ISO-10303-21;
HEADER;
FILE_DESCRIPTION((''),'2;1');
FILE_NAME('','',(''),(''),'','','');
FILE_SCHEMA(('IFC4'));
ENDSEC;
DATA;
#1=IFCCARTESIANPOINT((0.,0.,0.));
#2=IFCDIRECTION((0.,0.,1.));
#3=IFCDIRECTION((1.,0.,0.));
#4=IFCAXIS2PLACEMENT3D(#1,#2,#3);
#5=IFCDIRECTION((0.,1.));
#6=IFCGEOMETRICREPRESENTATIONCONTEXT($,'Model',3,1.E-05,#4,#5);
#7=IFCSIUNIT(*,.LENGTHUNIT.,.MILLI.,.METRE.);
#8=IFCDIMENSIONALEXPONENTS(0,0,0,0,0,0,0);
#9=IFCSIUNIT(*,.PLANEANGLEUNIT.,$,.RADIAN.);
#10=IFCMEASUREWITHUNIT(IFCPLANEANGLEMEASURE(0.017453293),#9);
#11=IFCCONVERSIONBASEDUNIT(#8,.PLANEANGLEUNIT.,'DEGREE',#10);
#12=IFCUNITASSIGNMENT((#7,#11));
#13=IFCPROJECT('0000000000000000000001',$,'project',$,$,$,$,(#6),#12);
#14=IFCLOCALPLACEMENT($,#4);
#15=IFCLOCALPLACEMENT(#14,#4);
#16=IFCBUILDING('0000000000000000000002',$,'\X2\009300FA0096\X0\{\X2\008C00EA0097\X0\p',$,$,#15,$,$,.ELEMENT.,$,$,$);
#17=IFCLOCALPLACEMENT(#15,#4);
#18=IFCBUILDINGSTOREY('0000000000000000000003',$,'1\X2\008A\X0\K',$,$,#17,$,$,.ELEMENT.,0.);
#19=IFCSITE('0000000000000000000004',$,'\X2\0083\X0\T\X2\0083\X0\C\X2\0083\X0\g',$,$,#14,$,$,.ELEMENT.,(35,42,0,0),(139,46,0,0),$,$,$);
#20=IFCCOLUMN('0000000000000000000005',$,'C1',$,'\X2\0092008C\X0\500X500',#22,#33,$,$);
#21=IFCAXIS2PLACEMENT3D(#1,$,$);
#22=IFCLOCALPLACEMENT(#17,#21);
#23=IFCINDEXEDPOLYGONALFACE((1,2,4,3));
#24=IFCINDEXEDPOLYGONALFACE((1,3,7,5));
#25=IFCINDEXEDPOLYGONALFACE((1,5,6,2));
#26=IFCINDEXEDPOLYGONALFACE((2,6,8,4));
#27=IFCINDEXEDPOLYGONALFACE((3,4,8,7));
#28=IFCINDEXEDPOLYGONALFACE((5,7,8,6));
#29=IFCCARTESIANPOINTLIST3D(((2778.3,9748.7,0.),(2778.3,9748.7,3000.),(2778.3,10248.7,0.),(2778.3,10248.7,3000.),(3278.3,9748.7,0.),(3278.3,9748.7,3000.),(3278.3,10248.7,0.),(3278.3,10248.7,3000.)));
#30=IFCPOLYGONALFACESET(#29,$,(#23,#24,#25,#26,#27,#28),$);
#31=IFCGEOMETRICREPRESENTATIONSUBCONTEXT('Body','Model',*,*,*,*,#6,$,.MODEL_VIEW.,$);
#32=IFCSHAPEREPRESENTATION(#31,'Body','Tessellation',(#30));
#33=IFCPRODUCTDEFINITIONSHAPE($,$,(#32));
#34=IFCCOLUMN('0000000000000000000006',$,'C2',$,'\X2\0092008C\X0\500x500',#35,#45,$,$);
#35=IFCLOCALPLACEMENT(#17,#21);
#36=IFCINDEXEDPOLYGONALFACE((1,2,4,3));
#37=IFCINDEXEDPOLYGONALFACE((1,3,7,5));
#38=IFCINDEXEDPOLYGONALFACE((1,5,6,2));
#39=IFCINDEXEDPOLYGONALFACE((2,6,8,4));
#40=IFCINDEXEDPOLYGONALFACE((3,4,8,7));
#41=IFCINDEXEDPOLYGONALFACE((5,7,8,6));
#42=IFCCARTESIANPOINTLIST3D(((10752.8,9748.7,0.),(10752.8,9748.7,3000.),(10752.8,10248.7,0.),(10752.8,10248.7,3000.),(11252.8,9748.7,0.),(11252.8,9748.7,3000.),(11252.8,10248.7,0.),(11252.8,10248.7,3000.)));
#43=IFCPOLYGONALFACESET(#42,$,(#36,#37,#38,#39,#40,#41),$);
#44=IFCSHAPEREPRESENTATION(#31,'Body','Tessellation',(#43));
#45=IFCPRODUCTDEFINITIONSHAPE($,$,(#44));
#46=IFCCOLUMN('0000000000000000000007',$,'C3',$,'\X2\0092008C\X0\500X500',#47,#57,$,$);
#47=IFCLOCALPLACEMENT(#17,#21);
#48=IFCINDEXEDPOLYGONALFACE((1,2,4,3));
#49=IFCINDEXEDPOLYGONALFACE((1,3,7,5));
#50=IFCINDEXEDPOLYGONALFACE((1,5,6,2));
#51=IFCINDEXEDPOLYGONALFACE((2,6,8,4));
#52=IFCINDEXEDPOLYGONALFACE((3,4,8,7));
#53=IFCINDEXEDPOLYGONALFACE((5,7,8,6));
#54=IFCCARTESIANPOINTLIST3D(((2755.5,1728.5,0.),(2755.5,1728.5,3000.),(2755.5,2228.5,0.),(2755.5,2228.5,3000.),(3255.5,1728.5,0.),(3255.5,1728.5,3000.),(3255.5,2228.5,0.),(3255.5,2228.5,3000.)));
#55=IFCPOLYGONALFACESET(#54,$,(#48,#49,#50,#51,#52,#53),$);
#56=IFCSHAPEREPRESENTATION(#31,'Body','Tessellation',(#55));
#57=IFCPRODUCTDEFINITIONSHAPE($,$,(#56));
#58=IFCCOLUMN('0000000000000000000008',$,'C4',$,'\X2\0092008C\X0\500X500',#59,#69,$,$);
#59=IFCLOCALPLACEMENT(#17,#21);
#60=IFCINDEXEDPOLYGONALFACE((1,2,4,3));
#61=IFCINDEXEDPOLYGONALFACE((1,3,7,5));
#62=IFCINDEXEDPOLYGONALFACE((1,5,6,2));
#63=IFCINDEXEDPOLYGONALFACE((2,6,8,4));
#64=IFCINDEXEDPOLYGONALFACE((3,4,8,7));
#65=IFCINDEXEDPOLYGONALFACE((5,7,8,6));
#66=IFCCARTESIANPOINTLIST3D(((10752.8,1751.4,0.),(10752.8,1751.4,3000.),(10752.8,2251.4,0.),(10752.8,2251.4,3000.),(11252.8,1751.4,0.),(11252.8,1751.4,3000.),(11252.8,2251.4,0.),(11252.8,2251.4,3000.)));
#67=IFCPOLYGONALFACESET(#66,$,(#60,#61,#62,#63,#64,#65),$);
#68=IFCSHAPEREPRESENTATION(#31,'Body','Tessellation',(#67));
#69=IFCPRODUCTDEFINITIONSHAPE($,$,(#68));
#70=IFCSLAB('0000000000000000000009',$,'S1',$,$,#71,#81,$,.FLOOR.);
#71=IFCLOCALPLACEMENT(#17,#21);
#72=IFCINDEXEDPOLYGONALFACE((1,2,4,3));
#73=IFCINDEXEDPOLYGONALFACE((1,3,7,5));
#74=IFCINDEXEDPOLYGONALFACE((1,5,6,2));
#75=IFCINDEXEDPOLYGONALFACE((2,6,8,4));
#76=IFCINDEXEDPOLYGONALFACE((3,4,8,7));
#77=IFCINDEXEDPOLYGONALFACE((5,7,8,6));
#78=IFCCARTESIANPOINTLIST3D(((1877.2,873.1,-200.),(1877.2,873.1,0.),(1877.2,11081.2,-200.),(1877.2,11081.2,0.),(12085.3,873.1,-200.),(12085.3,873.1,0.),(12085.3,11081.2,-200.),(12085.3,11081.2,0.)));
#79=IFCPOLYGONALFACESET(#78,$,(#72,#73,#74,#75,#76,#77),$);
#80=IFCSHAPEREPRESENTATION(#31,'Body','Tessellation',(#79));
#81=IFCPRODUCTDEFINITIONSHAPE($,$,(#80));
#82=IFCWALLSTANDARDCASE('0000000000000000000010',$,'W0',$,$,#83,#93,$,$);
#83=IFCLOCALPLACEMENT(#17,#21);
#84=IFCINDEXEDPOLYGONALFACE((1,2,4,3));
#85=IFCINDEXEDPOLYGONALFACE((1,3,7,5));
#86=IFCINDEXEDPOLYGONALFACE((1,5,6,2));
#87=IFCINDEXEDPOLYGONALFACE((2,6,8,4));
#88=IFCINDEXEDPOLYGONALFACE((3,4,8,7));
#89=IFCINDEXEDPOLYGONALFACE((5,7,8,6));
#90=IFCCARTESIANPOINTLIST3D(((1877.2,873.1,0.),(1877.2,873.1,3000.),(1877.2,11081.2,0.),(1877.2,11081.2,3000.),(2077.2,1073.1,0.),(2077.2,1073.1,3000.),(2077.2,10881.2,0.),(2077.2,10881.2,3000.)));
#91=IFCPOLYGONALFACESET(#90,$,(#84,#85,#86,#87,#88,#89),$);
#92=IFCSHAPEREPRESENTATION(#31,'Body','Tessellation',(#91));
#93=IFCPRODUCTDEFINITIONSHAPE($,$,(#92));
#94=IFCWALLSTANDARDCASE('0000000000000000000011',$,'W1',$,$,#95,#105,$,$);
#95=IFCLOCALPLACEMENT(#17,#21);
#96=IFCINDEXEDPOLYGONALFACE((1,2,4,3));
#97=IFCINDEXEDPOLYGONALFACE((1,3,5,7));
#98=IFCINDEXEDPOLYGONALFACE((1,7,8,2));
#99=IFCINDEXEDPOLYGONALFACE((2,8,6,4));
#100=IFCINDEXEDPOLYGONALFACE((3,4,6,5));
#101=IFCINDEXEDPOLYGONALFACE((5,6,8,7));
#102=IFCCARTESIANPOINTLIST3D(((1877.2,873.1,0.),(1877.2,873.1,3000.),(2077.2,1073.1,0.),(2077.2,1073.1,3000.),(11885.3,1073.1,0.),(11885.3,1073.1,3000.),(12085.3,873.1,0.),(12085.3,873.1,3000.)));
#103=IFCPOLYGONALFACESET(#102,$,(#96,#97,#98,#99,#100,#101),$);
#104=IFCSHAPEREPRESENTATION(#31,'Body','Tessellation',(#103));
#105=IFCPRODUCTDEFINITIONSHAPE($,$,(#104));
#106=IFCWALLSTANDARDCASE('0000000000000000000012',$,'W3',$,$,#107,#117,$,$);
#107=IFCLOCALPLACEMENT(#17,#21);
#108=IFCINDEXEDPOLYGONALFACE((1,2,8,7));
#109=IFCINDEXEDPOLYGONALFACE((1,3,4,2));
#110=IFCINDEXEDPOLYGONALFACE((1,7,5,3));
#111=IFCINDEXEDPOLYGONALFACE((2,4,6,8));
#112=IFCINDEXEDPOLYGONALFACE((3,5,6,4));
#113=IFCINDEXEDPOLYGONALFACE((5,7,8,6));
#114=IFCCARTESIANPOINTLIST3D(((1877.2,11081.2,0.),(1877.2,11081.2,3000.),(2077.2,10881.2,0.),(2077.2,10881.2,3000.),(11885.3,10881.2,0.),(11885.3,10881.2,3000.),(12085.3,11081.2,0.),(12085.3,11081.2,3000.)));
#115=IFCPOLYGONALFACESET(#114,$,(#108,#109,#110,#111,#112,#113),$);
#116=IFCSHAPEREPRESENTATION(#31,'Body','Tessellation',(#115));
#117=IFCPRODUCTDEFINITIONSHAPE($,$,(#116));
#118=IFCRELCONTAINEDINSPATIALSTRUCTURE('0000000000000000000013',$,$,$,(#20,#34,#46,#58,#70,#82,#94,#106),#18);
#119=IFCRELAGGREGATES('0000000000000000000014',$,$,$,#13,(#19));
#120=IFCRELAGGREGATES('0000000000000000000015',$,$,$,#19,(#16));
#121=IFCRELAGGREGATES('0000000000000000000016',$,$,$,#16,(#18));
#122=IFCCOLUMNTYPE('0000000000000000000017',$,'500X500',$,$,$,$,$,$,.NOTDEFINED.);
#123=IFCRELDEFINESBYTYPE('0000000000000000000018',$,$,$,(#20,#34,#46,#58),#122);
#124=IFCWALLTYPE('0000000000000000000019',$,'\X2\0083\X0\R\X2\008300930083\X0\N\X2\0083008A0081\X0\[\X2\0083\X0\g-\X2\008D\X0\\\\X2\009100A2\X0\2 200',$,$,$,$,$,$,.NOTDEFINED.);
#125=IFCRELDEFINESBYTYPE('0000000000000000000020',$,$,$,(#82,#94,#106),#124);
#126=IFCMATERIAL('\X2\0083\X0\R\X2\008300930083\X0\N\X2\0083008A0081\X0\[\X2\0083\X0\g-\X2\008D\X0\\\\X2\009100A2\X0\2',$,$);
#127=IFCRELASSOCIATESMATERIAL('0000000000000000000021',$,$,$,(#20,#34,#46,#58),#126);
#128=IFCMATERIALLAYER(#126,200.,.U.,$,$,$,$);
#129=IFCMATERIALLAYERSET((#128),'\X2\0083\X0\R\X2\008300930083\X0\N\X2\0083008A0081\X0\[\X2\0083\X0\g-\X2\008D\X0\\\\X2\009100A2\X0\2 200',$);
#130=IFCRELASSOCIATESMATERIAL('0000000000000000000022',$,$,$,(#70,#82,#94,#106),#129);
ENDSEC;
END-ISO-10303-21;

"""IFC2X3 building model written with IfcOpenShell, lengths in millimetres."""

from ifc_helpers import new_model, entity, si_unit, converted_unit, direction, frame, origin_with_axes, origin_2d_with_axis, place, context, subcontext, project, spatial, polyline, rectangle, outline, extrude, material, layer, layer_set, layer_usage, type_object, element, save


model = new_model("IFC2X3")

# Units and contexts
model_context = context("Model", 3, precision=1e-05, world=origin_with_axes(), true_north=direction((0.0, 1.0)))
body_context = subcontext(model_context, "Body", "Model", "MODEL_VIEW")
ifc_project = project(units=[si_unit("LENGTHUNIT", "METRE", prefix="MILLI"), converted_unit("PLANEANGLEUNIT", "DEGREE", entity("IfcPlaneAngleMeasure", 0.017453293), si_unit("PLANEANGLEUNIT", "RADIAN"), dimensions=[0, 0, 0, 0, 0, 0, 0])], contexts=[model_context])

# Site, building, storey
site_placement = place(None, origin_with_axes())
site = spatial("IfcSite", under=ifc_project, at=site_placement, Name="\u0083T\u0083C\u0083g", CompositionType="ELEMENT", RefLatitude=(35, 42, 0, 0), RefLongitude=(139, 46, 0, 0))
building_placement = place(site_placement, origin_with_axes())
building = spatial("IfcBuilding", under=site, at=building_placement, Name="\u0093ú\u0096{\u008cê\u0097p", CompositionType="ELEMENT")
storey_placement = place(building_placement, origin_with_axes())
storey = spatial("IfcBuildingStorey", under=building, at=storey_placement, Name="1\u008aK", CompositionType="ELEMENT", Elevation=0.0)

# Columns
ifc_material = material(Name="\u0083R\u0083\u0093\u0083N\u0083\u008a\u0081[\u0083g-\u008d\\\u0091¢2")
column_type = type_object("IfcColumnType", Name="500X500", PredefinedType="NOTDEFINED")
column_1_placement = place(storey_placement, frame((3028.3, 9998.7, 0.0), z_axis=(0.0, 0.0, 1.0), x_axis=(1.0, 0.0, 0.0)))
element("IfcColumn", 1, at=column_1_placement, inside=storey, type_object=column_type, material=ifc_material, Name="C1", ObjectType="\u0092\u008c500X500", context=body_context, shape_type="SweptSolid", body=[
    extrude(rectangle(XDim=500.0, YDim=500.0, at=origin_2d_with_axis()), origin_with_axes(), (0.0, 0.0, 1.0), 3000.0),
])
column_2_placement = place(storey_placement, frame((11002.8, 9998.7, 0.0), z_axis=(0.0, 0.0, 1.0), x_axis=(1.0, 0.0, 0.0)))
element("IfcColumn", 2, at=column_2_placement, inside=storey, type_object=column_type, material=ifc_material, Name="C2", ObjectType="\u0092\u008c500x500", context=body_context, shape_type="SweptSolid", body=[
    extrude(rectangle(XDim=500.0, YDim=500.0, at=origin_2d_with_axis()), origin_with_axes(), (0.0, 0.0, 1.0), 3000.0),
])
for number, where, z_axis, x_axis, name in (
    (3, (3005.5, 1978.5, 0.0), (0.0, 0.0, 1.0), (1.0, 0.0, 0.0), "C3"),
    (4, (11002.8, 2001.4, 0.0), (0.0, 0.0, 1.0), (1.0, 0.0, 0.0), "C4"),
):
    element("IfcColumn", number, at=place(storey_placement, frame(where, z_axis=z_axis, x_axis=x_axis)), inside=storey, type_object=column_type, material=ifc_material, Name=name, ObjectType="\u0092\u008c500X500", context=body_context, shape_type="SweptSolid", body=[
        extrude(rectangle(XDim=500.0, YDim=500.0, at=origin_2d_with_axis()), origin_with_axes(), (0.0, 0.0, 1.0), 3000.0),
    ])

# Slab
ifc_layer = layer(ifc_material, 200.0, ventilated="UNKNOWN")
ifc_layer_set = layer_set([ifc_layer], Name="\u0083R\u0083\u0093\u0083N\u0083\u008a\u0081[\u0083g-\u008d\\\u0091¢2 200")
ifc_layer_usage_1 = layer_usage(ifc_layer_set, "AXIS3", "NEGATIVE", 200.0)
slab_placement = place(storey_placement, frame((1877.2, 11081.2, -200.0), z_axis=(0.0, 0.0, 1.0), x_axis=(1.0, 0.0, 0.0)))
element("IfcSlab", 5, at=slab_placement, inside=storey, material=ifc_layer_usage_1, Name="S1", PredefinedType="FLOOR", context=body_context, shape_type="SweptSolid", body=[
    extrude(outline(polyline([(0.0, 0.0), (0.0, -10208.1), (10208.1, -10208.1), (10208.1, 0.0), (0.0, 0.0)])), origin_with_axes(), (0.0, 0.0, 1.0), 200.0),
])

# Walls
ifc_layer_usage_2 = layer_usage(ifc_layer_set, "AXIS2", "NEGATIVE", 100.0)
wall_type = type_object("IfcWallType", Name="\u0083R\u0083\u0093\u0083N\u0083\u008a\u0081[\u0083g-\u008d\\\u0091¢2 200", PredefinedType="NOTDEFINED")
wall_1_placement = place(storey_placement, frame((1977.2, 10981.2, 0.0), z_axis=(0.0, 0.0, 1.0), x_axis=(0.0, -1.0, 0.0)))
element("IfcWallStandardCase", 6, at=wall_1_placement, inside=storey, type_object=wall_type, material=ifc_layer_usage_2, Name="W0", context=body_context, shape_type="SweptSolid", body=[
    extrude(outline(polyline([(-100.0, -100.0), (10108.1, -100.0), (9908.1, 100.0), (100.0, 100.0), (-100.0, -100.0)])), origin_with_axes(), (0.0, 0.0, 1.0), 3000.0),
])
ifc_layer_usage_3 = layer_usage(ifc_layer_set, "AXIS2", "NEGATIVE", 100.0)
wall_2_placement = place(storey_placement, frame((1977.2, 973.1, 0.0), z_axis=(0.0, 0.0, 1.0), x_axis=(1.0, 0.0, 0.0)))
element("IfcWallStandardCase", 7, at=wall_2_placement, inside=storey, type_object=wall_type, material=ifc_layer_usage_3, Name="W1", context=body_context, shape_type="SweptSolid", body=[
    extrude(outline(polyline([(-100.0, -100.0), (10108.1, -100.0), (9908.1, 100.0), (100.0, 100.0), (-100.0, -100.0)])), origin_with_axes(), (0.0, 0.0, 1.0), 3000.0),
])

# Wall
ifc_layer_usage_4 = layer_usage(ifc_layer_set, "AXIS2", "NEGATIVE", 100.0)
wall_3_placement = place(storey_placement, frame((11985.3, 10981.2, 0.0), z_axis=(0.0, 0.0, 1.0), x_axis=(-1.0, 0.0, 0.0)))
element("IfcWallStandardCase", 8, at=wall_3_placement, inside=storey, type_object=wall_type, material=ifc_layer_usage_4, Name="W3", context=body_context, shape_type="SweptSolid", body=[
    extrude(outline(polyline([(-100.0, -100.0), (10108.1, -100.0), (9908.1, 100.0), (100.0, 100.0), (-100.0, -100.0)])), origin_with_axes(), (0.0, 0.0, 1.0), 3000.0),
])

save(model, "model.ifc")
